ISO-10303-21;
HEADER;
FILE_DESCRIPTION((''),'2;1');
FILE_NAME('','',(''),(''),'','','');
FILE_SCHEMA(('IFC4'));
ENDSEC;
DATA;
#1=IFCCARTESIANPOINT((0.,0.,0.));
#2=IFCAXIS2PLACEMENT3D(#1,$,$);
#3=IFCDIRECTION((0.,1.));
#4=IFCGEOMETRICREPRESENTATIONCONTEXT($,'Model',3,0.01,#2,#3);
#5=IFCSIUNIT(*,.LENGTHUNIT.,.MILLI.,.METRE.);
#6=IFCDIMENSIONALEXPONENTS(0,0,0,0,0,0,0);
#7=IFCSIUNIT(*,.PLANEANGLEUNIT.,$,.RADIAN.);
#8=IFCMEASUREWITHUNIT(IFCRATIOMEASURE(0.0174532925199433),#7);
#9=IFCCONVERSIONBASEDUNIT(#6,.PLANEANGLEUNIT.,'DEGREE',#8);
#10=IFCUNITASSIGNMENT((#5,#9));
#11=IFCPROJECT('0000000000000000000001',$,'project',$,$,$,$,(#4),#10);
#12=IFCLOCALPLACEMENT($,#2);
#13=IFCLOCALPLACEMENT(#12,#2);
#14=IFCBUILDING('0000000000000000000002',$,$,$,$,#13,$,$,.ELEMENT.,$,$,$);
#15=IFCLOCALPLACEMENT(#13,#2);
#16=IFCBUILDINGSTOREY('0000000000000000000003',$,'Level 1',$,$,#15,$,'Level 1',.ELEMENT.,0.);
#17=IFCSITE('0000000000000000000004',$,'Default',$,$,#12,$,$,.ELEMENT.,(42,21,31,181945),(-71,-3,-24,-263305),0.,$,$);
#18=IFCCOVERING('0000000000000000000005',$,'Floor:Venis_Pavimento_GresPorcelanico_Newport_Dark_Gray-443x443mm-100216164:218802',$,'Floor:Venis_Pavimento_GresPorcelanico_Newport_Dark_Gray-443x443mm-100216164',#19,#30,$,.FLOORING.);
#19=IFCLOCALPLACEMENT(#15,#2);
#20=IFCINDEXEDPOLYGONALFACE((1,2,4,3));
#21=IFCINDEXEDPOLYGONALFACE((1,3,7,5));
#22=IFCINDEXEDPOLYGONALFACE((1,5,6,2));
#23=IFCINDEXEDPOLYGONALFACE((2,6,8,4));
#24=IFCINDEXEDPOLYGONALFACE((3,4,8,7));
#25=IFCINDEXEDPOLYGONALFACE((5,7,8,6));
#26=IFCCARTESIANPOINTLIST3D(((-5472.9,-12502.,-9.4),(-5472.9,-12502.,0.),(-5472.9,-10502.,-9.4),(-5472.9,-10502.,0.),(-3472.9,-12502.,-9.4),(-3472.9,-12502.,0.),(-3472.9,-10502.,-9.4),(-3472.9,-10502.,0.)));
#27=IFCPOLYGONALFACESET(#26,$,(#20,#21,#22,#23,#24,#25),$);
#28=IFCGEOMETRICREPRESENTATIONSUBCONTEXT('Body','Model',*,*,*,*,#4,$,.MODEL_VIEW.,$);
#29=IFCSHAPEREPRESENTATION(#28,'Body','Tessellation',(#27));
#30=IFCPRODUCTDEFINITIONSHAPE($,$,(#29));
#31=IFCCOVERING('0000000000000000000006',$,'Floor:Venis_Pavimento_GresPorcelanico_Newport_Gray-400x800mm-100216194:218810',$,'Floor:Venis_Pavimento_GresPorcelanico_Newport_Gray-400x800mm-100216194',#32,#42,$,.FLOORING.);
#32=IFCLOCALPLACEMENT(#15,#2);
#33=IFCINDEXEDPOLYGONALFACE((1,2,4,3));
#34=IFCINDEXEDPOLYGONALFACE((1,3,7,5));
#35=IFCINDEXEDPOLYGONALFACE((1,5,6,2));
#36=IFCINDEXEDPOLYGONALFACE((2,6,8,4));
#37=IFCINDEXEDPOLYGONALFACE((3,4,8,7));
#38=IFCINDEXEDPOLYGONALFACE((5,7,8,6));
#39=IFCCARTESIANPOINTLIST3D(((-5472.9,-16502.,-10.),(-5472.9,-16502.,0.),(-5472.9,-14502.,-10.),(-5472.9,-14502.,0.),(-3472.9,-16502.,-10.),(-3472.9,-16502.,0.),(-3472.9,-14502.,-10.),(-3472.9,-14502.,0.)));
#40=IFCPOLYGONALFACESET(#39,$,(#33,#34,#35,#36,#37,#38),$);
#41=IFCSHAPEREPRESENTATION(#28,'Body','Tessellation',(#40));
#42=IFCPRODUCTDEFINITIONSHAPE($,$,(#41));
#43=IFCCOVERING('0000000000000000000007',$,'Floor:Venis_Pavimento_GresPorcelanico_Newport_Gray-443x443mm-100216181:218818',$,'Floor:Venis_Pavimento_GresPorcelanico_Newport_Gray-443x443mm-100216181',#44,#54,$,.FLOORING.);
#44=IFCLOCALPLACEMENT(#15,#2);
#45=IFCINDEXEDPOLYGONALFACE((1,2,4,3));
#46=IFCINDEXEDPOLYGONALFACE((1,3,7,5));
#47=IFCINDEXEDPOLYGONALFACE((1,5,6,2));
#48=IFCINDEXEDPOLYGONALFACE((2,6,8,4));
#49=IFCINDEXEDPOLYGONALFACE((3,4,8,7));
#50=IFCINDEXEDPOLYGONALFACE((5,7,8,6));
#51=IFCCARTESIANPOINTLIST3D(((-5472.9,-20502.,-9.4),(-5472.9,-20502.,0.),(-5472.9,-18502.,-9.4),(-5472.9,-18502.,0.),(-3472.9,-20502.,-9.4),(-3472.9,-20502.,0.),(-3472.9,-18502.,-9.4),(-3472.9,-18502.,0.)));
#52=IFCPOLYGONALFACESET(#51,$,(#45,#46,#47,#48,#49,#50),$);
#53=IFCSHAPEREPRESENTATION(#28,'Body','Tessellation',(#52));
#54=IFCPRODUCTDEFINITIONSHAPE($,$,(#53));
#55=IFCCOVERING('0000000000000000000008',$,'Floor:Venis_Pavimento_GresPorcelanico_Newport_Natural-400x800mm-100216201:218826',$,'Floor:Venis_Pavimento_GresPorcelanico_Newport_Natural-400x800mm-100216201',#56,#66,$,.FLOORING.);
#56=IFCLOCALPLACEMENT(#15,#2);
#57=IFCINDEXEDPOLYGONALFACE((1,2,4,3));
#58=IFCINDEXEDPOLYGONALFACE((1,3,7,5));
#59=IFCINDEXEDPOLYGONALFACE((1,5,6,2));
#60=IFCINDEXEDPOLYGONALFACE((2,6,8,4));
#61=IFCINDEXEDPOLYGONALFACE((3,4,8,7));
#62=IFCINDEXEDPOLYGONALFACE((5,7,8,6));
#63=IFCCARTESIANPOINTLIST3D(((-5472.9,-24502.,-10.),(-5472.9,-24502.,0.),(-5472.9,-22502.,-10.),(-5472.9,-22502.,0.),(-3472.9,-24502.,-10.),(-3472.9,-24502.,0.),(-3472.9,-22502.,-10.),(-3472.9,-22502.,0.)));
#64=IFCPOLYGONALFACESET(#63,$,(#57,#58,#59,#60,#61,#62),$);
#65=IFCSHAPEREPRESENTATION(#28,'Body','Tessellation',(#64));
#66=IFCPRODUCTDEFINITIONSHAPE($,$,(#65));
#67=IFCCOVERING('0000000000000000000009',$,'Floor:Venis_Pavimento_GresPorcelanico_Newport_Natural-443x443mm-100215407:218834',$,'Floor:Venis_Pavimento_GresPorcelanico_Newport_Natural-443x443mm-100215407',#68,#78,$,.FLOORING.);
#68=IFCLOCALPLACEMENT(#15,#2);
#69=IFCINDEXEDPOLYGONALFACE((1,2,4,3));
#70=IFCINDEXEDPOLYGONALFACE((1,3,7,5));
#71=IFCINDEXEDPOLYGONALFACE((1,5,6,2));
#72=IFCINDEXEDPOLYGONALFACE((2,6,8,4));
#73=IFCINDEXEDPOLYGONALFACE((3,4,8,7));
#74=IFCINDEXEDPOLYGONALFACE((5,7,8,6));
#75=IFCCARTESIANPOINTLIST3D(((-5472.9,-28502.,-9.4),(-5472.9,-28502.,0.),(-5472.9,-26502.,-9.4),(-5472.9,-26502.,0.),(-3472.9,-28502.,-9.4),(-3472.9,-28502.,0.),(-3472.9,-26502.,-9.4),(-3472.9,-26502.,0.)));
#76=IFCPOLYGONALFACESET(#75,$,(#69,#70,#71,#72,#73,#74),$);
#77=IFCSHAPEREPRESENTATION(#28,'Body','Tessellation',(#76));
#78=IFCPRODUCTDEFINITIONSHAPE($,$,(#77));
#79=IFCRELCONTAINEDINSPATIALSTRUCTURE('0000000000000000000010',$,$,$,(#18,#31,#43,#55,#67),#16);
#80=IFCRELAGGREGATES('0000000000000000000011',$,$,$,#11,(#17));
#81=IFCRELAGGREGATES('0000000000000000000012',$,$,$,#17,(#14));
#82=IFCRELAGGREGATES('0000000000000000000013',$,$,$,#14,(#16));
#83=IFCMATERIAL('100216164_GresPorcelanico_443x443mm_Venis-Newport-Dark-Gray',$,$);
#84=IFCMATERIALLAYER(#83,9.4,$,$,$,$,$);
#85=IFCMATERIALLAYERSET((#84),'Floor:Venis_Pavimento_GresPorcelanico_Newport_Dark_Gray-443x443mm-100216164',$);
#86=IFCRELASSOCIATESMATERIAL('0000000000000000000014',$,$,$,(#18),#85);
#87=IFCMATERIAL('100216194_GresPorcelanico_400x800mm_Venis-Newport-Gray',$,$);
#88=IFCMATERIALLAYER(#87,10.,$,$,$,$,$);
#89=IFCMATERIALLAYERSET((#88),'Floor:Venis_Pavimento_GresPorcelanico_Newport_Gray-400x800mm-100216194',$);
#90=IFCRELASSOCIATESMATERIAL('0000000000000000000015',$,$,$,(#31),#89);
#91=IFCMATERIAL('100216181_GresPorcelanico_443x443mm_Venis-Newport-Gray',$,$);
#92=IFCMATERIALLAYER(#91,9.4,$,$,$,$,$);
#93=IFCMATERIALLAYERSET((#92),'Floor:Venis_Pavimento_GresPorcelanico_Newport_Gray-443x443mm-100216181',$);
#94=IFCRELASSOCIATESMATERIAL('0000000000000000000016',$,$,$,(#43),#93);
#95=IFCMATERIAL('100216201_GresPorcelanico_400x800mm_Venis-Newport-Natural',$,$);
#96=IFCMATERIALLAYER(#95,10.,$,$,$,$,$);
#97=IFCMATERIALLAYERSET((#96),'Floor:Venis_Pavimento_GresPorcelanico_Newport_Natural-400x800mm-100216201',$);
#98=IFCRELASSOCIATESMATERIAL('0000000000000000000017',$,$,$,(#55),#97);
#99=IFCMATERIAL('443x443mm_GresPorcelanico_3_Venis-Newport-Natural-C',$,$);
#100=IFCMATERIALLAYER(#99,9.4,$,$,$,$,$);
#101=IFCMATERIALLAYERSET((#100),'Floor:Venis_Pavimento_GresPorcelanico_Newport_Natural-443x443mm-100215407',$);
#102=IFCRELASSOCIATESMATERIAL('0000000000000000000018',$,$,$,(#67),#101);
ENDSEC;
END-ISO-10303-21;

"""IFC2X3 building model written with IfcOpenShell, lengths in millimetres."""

from ifc_helpers import new_model, entity, si_unit, converted_unit, direction, frame, frame_2d, origin, place, context, subcontext, project, spatial, rectangle, extrude, material, layer, layer_set, layer_usage, element, save


model = new_model("IFC2X3")

# Units and contexts
model_context = context("Model", 3, precision=0.01, world=origin(), true_north=direction((0.0, 1.0)))
body_context = subcontext(model_context, "Body", "Model", "MODEL_VIEW")
ifc_project = project(units=[si_unit("LENGTHUNIT", "METRE", prefix="MILLI"), converted_unit("PLANEANGLEUNIT", "DEGREE", entity("IfcRatioMeasure", 0.0174532925199433), si_unit("PLANEANGLEUNIT", "RADIAN"), dimensions=[0, 0, 0, 0, 0, 0, 0])], contexts=[model_context])

# Site, building, storey
site_placement = place(None, origin())
site = spatial("IfcSite", under=ifc_project, at=site_placement, Name="Default", CompositionType="ELEMENT", RefLatitude=(42, 21, 31, 181945), RefLongitude=(-71, -3, -24, -263305), RefElevation=0.0)
building_placement = place(site_placement, origin())
building = spatial("IfcBuilding", under=site, at=building_placement, CompositionType="ELEMENT")
storey_placement = place(building_placement, origin())
storey = spatial("IfcBuildingStorey", under=building, at=storey_placement, Name="Level 1", LongName="Level 1", CompositionType="ELEMENT", Elevation=0.0)

# Coverings
ifc_material_1 = material(Name="100216164_GresPorcelanico_443x443mm_Venis-Newport-Dark-Gray")
ifc_layer_1 = layer(ifc_material_1, 9.4)
ifc_layer_set_1 = layer_set([ifc_layer_1], Name="Floor:Venis_Pavimento_GresPorcelanico_Newport_Dark_Gray-443x443mm-100216164")
ifc_layer_usage_1 = layer_usage(ifc_layer_set_1, "AXIS3", "POSITIVE", 0.0)
covering_1_placement = place(storey_placement, origin())
element("IfcCovering", 1, at=covering_1_placement, inside=storey, material=ifc_layer_usage_1, Name="Floor:Venis_Pavimento_GresPorcelanico_Newport_Dark_Gray-443x443mm-100216164:218802", ObjectType="Floor:Venis_Pavimento_GresPorcelanico_Newport_Dark_Gray-443x443mm-100216164", PredefinedType="FLOORING", context=body_context, shape_type="SweptSolid", body=[
    extrude(rectangle(XDim=2000.0, YDim=2000.0, at=frame_2d((0.0, 0.0), x_axis=(1.0, 0.0))), frame((-4472.9, -11502.0, 0.0), z_axis=(0.0, 0.0, -1.0), x_axis=(0.0, 1.0, 0.0)), (0.0, 0.0, 1.0), 9.4),
])
ifc_material_2 = material(Name="100216194_GresPorcelanico_400x800mm_Venis-Newport-Gray")
ifc_layer_2 = layer(ifc_material_2, 10.0)
ifc_layer_set_2 = layer_set([ifc_layer_2], Name="Floor:Venis_Pavimento_GresPorcelanico_Newport_Gray-400x800mm-100216194")
ifc_layer_usage_2 = layer_usage(ifc_layer_set_2, "AXIS3", "POSITIVE", 0.0)
covering_2_placement = place(storey_placement, origin())
element("IfcCovering", 2, at=covering_2_placement, inside=storey, material=ifc_layer_usage_2, Name="Floor:Venis_Pavimento_GresPorcelanico_Newport_Gray-400x800mm-100216194:218810", ObjectType="Floor:Venis_Pavimento_GresPorcelanico_Newport_Gray-400x800mm-100216194", PredefinedType="FLOORING", context=body_context, shape_type="SweptSolid", body=[
    extrude(rectangle(XDim=2000.0, YDim=2000.0, at=frame_2d((0.0, 0.0), x_axis=(1.0, 0.0))), frame((-4472.9, -15502.0, 0.0), z_axis=(0.0, 0.0, -1.0), x_axis=(0.0, 1.0, 0.0)), (0.0, 0.0, 1.0), 10.0),
])
ifc_material_3 = material(Name="100216181_GresPorcelanico_443x443mm_Venis-Newport-Gray")
ifc_layer_3 = layer(ifc_material_3, 9.4)
ifc_layer_set_3 = layer_set([ifc_layer_3], Name="Floor:Venis_Pavimento_GresPorcelanico_Newport_Gray-443x443mm-100216181")
ifc_layer_usage_3 = layer_usage(ifc_layer_set_3, "AXIS3", "POSITIVE", 0.0)
covering_3_placement = place(storey_placement, origin())
element("IfcCovering", 3, at=covering_3_placement, inside=storey, material=ifc_layer_usage_3, Name="Floor:Venis_Pavimento_GresPorcelanico_Newport_Gray-443x443mm-100216181:218818", ObjectType="Floor:Venis_Pavimento_GresPorcelanico_Newport_Gray-443x443mm-100216181", PredefinedType="FLOORING", context=body_context, shape_type="SweptSolid", body=[
    extrude(rectangle(XDim=2000.0, YDim=2000.0, at=frame_2d((0.0, 0.0), x_axis=(1.0, 0.0))), frame((-4472.9, -19502.0, 0.0), z_axis=(0.0, 0.0, -1.0), x_axis=(0.0, 1.0, 0.0)), (0.0, 0.0, 1.0), 9.4),
])
ifc_material_4 = material(Name="100216201_GresPorcelanico_400x800mm_Venis-Newport-Natural")
ifc_layer_4 = layer(ifc_material_4, 10.0)
ifc_layer_set_4 = layer_set([ifc_layer_4], Name="Floor:Venis_Pavimento_GresPorcelanico_Newport_Natural-400x800mm-100216201")
ifc_layer_usage_4 = layer_usage(ifc_layer_set_4, "AXIS3", "POSITIVE", 0.0)
covering_4_placement = place(storey_placement, origin())
element("IfcCovering", 4, at=covering_4_placement, inside=storey, material=ifc_layer_usage_4, Name="Floor:Venis_Pavimento_GresPorcelanico_Newport_Natural-400x800mm-100216201:218826", ObjectType="Floor:Venis_Pavimento_GresPorcelanico_Newport_Natural-400x800mm-100216201", PredefinedType="FLOORING", context=body_context, shape_type="SweptSolid", body=[
    extrude(rectangle(XDim=2000.0, YDim=2000.0, at=frame_2d((0.0, 0.0), x_axis=(1.0, 0.0))), frame((-4472.9, -23502.0, 0.0), z_axis=(0.0, 0.0, -1.0), x_axis=(0.0, 1.0, 0.0)), (0.0, 0.0, 1.0), 10.0),
])
ifc_material_5 = material(Name="443x443mm_GresPorcelanico_3_Venis-Newport-Natural-C")
ifc_layer_5 = layer(ifc_material_5, 9.4)
ifc_layer_set_5 = layer_set([ifc_layer_5], Name="Floor:Venis_Pavimento_GresPorcelanico_Newport_Natural-443x443mm-100215407")
ifc_layer_usage_5 = layer_usage(ifc_layer_set_5, "AXIS3", "POSITIVE", 0.0)
covering_5_placement = place(storey_placement, origin())
element("IfcCovering", 5, at=covering_5_placement, inside=storey, material=ifc_layer_usage_5, Name="Floor:Venis_Pavimento_GresPorcelanico_Newport_Natural-443x443mm-100215407:218834", ObjectType="Floor:Venis_Pavimento_GresPorcelanico_Newport_Natural-443x443mm-100215407", PredefinedType="FLOORING", context=body_context, shape_type="SweptSolid", body=[
    extrude(rectangle(XDim=2000.0, YDim=2000.0, at=frame_2d((0.0, 0.0), x_axis=(1.0, 0.0))), frame((-4472.9, -27502.0, 0.0), z_axis=(0.0, 0.0, -1.0), x_axis=(0.0, 1.0, 0.0)), (0.0, 0.0, 1.0), 9.4),
])

save(model, "model.ifc")
